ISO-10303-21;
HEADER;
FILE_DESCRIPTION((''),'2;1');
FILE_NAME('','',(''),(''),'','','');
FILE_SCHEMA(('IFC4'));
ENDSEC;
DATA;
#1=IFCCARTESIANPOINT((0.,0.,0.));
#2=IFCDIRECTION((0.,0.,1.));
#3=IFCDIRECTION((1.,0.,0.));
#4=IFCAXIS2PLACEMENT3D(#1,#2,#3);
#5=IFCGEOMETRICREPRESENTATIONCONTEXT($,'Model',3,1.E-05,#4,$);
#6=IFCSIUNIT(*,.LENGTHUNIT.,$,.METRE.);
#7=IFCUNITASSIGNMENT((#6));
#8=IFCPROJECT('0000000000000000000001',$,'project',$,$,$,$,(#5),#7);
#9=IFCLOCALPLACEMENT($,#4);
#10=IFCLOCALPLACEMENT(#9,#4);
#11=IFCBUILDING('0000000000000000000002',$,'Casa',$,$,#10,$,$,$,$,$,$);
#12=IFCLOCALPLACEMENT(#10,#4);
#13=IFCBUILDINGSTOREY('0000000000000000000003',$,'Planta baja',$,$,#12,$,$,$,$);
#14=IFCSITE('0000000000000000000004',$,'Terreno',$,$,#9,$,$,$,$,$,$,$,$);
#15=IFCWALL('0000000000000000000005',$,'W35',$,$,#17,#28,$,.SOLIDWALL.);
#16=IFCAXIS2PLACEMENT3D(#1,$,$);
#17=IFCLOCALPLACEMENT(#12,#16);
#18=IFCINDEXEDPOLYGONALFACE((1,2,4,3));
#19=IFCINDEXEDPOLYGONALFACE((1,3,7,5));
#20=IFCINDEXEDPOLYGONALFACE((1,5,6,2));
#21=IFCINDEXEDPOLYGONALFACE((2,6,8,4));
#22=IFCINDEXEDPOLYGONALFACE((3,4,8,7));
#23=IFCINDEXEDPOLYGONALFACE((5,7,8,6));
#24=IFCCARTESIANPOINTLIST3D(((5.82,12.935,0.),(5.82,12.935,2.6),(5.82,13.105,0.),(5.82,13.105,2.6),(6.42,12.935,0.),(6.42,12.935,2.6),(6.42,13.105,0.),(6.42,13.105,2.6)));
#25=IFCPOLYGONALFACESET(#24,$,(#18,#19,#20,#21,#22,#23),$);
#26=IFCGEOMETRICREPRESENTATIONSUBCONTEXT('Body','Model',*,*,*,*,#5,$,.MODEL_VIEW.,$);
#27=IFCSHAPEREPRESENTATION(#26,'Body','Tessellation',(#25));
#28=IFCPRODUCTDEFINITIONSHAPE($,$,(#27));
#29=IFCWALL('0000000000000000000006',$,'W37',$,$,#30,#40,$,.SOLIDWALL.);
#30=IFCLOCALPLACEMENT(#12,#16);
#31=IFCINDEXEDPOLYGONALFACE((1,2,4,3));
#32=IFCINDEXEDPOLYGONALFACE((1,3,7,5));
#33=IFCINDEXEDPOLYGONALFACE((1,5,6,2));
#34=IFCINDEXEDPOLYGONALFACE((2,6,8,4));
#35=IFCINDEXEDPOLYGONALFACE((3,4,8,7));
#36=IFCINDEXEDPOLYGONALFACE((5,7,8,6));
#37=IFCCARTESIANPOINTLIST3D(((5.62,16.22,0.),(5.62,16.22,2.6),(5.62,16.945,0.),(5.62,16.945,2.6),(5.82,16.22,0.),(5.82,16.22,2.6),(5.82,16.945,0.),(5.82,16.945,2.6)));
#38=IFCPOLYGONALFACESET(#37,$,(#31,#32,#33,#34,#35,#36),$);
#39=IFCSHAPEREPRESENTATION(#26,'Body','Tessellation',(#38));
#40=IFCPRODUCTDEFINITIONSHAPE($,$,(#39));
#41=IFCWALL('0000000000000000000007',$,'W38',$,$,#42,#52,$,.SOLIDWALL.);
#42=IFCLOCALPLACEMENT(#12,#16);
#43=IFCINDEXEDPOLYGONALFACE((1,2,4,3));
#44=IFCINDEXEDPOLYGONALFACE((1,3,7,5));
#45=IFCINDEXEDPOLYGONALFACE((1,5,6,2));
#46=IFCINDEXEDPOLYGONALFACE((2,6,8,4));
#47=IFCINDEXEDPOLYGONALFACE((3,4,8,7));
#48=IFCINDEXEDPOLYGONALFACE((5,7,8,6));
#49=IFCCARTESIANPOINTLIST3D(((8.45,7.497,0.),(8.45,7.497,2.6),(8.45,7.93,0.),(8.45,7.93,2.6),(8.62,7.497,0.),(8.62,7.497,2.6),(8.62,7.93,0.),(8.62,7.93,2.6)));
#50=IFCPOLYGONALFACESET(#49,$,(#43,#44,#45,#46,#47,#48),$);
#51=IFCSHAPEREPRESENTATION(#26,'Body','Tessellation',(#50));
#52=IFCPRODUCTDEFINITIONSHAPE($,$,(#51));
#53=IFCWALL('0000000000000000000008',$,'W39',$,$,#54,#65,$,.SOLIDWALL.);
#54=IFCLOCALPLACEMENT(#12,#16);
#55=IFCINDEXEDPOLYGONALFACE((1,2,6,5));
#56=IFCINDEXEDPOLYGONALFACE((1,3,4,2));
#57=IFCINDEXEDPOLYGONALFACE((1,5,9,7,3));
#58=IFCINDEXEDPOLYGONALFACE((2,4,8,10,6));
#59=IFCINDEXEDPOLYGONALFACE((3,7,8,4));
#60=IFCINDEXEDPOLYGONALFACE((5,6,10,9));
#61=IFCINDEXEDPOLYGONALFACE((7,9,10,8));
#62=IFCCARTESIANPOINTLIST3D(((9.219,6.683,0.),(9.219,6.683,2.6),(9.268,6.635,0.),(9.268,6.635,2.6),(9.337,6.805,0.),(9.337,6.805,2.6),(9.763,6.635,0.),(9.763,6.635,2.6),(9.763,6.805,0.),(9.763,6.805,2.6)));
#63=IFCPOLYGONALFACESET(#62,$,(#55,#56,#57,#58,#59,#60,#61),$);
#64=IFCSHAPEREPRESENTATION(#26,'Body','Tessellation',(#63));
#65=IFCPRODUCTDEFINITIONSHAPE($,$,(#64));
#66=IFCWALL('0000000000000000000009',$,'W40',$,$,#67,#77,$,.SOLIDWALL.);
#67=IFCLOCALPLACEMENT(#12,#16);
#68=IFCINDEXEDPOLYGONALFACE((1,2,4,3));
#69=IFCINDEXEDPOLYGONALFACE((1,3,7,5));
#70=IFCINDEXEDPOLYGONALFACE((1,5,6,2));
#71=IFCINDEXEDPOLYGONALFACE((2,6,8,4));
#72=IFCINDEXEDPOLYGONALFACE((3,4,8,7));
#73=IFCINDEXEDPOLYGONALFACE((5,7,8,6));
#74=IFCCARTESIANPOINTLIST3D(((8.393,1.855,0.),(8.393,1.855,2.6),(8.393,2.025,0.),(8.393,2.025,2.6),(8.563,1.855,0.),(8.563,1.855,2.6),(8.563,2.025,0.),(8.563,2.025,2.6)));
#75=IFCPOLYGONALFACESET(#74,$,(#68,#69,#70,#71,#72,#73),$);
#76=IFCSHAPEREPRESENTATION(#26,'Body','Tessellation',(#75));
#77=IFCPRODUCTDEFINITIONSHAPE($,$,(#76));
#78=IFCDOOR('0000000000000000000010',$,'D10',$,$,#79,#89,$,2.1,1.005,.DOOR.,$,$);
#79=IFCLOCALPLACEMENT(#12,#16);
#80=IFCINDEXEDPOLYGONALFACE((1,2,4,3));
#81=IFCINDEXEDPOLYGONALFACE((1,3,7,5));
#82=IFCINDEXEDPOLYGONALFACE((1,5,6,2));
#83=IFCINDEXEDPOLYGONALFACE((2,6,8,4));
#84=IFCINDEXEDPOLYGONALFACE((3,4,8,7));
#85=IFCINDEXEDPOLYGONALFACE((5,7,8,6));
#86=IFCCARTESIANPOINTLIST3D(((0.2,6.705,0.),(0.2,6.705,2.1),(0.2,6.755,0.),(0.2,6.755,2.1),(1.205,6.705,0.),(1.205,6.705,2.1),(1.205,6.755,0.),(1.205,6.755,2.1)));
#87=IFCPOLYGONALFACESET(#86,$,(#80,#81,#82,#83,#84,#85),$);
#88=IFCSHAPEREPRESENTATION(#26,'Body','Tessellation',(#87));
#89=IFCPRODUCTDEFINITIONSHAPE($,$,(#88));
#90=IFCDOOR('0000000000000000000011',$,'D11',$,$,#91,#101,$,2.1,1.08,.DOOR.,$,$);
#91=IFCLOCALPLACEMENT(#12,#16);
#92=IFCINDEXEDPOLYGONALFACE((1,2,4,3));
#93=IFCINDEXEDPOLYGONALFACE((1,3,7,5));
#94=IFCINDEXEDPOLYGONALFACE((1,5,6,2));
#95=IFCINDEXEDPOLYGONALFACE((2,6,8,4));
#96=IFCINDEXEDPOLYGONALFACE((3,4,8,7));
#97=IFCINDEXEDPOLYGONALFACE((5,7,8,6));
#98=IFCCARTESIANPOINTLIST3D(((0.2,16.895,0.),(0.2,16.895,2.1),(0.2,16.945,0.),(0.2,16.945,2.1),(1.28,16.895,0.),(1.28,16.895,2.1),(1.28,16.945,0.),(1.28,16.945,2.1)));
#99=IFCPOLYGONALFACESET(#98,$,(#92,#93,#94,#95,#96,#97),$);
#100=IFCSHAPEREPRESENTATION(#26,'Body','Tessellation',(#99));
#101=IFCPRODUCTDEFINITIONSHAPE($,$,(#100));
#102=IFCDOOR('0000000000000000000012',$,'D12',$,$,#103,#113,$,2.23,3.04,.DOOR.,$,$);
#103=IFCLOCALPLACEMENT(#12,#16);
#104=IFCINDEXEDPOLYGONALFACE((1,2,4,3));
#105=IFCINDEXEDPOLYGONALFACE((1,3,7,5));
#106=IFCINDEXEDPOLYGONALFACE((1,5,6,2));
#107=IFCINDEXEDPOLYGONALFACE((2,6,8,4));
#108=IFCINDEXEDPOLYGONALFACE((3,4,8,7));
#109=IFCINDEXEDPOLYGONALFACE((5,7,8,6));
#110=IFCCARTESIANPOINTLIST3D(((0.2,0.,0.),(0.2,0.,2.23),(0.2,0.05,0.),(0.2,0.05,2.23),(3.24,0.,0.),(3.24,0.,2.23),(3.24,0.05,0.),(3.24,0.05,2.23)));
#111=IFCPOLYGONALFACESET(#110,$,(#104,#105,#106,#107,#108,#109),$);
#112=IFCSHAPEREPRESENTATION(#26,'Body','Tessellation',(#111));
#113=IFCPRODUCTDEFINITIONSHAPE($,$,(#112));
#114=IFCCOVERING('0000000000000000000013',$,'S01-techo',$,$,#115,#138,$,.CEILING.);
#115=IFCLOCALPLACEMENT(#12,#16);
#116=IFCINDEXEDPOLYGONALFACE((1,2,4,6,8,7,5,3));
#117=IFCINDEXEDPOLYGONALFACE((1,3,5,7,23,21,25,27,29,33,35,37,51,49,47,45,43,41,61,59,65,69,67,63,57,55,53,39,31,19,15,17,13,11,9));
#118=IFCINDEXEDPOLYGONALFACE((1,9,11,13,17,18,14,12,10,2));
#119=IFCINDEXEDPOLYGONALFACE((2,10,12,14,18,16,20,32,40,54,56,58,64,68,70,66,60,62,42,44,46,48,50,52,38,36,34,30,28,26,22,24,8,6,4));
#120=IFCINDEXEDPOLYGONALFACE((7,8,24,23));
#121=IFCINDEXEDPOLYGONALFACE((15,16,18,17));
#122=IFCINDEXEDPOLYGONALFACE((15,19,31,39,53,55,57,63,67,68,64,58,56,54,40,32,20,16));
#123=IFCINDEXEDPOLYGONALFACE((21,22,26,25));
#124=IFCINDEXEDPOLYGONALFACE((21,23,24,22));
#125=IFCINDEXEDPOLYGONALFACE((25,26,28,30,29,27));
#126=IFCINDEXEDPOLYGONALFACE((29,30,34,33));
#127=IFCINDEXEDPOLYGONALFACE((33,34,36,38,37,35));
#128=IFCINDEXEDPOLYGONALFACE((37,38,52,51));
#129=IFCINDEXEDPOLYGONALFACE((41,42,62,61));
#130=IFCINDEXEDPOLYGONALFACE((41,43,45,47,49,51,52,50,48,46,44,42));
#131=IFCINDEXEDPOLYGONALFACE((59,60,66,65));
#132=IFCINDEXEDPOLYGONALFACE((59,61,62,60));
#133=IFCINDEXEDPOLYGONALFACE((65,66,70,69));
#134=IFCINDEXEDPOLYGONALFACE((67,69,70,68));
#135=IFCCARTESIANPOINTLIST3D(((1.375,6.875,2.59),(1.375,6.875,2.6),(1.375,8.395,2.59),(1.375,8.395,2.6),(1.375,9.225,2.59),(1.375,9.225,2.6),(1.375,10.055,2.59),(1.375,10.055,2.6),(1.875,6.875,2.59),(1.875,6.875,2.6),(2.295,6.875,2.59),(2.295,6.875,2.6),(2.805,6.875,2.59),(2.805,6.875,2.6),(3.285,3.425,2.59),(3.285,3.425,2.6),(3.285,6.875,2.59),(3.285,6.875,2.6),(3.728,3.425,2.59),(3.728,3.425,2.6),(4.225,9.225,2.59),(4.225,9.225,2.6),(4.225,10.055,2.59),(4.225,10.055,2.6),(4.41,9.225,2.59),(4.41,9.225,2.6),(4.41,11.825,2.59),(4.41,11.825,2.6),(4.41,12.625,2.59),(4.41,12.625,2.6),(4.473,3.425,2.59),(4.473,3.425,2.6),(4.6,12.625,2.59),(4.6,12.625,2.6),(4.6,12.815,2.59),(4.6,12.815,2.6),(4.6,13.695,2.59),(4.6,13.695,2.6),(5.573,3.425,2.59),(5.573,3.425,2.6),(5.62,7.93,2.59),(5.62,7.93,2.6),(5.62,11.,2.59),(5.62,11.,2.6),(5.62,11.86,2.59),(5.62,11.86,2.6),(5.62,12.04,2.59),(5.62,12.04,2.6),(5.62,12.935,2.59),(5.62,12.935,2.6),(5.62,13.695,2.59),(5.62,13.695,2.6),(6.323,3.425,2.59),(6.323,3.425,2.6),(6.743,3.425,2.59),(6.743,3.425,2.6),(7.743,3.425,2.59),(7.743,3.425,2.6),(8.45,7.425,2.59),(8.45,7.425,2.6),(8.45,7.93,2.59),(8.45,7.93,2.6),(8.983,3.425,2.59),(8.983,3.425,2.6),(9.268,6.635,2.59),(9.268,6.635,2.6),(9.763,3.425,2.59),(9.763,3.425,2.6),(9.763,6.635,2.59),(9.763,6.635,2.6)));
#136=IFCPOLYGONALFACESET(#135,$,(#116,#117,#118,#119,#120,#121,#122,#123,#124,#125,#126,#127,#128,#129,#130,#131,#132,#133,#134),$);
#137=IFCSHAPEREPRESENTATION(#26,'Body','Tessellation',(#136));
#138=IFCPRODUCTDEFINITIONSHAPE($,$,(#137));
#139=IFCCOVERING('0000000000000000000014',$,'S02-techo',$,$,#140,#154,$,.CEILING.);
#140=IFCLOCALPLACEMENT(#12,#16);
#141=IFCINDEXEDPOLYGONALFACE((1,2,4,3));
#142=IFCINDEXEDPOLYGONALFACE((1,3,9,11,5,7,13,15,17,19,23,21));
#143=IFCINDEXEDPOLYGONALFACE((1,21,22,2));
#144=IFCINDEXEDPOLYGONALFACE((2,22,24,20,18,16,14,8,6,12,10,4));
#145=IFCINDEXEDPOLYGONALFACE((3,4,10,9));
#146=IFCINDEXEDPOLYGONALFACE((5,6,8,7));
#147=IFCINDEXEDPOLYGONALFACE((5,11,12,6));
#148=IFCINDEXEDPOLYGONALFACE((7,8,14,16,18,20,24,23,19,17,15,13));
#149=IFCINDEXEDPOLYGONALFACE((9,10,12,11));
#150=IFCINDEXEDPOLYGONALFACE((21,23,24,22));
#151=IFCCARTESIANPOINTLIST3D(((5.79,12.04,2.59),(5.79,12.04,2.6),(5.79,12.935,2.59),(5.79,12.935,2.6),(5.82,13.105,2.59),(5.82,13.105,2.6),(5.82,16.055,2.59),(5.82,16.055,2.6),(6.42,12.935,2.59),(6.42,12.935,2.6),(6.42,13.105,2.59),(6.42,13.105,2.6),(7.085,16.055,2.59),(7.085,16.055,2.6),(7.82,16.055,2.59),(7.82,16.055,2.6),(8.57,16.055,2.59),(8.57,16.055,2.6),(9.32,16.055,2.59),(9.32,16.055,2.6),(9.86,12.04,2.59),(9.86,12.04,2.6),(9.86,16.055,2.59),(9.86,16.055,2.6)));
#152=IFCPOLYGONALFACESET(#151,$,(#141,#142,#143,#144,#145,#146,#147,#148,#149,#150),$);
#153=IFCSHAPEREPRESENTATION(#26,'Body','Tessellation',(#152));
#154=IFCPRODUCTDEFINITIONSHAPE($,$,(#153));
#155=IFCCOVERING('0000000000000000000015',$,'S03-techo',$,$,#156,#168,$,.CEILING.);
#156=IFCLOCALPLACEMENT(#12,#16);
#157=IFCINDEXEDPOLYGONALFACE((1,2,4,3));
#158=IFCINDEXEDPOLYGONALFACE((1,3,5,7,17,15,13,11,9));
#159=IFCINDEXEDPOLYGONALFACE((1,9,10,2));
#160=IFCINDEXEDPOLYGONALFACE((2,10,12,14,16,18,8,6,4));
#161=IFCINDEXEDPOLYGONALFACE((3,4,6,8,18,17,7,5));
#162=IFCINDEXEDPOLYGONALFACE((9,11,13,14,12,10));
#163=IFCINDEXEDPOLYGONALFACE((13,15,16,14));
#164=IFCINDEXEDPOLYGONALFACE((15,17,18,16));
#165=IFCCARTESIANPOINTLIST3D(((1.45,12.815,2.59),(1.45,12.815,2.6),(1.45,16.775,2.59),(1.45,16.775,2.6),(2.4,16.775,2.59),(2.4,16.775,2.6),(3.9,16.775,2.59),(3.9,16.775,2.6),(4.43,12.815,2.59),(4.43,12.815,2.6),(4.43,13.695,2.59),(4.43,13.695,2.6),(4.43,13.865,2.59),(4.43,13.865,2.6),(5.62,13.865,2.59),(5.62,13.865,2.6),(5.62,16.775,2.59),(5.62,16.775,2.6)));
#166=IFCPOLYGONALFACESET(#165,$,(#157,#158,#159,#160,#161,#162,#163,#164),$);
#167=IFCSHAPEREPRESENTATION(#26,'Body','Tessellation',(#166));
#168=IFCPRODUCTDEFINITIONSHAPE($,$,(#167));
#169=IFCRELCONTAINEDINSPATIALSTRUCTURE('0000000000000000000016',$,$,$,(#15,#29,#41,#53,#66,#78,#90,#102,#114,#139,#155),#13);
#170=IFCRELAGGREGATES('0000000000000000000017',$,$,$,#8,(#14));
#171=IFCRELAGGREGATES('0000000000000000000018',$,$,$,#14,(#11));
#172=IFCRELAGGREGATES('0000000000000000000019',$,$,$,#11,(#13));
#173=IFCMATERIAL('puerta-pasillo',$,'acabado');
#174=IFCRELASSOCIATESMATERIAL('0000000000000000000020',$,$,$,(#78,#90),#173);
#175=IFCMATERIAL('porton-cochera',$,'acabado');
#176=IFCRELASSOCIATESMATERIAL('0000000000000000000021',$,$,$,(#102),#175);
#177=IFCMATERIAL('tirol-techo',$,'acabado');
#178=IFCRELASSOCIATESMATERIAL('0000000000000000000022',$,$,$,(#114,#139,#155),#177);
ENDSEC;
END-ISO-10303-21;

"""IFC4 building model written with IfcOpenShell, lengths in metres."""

from ifc_helpers import new_model, si_unit, frame, origin_with_axes, place, context, subcontext, project, spatial, line, indexed_curve, outline, extrude, material, element, save


model = new_model("IFC4")

# Units and contexts
model_context = context("Model", 3, precision=1e-05, world=origin_with_axes())
body_context = subcontext(model_context, "Body", "Model", "MODEL_VIEW")
ifc_project = project(units=[si_unit("LENGTHUNIT", "METRE")], contexts=[model_context])

# Site, building, storey
site_placement = place(None, origin_with_axes())
site = spatial("IfcSite", under=ifc_project, at=site_placement, Name="Terreno")
building_placement = place(site_placement, origin_with_axes())
building = spatial("IfcBuilding", under=site, at=building_placement, Name="Casa")
storey_placement = place(building_placement, origin_with_axes())
storey = spatial("IfcBuildingStorey", under=building, at=storey_placement, Name="Planta baja")

# Walls
wall_1_placement = place(storey_placement, origin_with_axes())
element("IfcWall", 1, at=wall_1_placement, inside=storey, Name="W35", PredefinedType="SOLIDWALL", context=body_context, shape_type="SweptSolid", body=[
    extrude(outline(indexed_curve([(6.42, 13.105), (6.42, 12.935), (5.82, 12.935), (5.82, 13.105)], segments=[line(1, 2, 3, 4, 1)])), origin_with_axes(), (0.0, 0.0, 1.0), 2.6),
])
wall_2_placement = place(storey_placement, origin_with_axes())
element("IfcWall", 2, at=wall_2_placement, inside=storey, Name="W37", PredefinedType="SOLIDWALL", context=body_context, shape_type="SweptSolid", body=[
    extrude(outline(indexed_curve([(5.62, 16.945), (5.82, 16.945), (5.82, 16.22), (5.62, 16.22)], segments=[line(1, 2, 3, 4, 1)])), origin_with_axes(), (0.0, 0.0, 1.0), 2.6),
])
wall_3_placement = place(storey_placement, origin_with_axes())
element("IfcWall", 3, at=wall_3_placement, inside=storey, Name="W38", PredefinedType="SOLIDWALL", context=body_context, shape_type="SweptSolid", body=[
    extrude(outline(indexed_curve([(8.62, 7.93), (8.62, 7.497), (8.45, 7.497), (8.45, 7.93)], segments=[line(1, 2, 3, 4, 1)])), origin_with_axes(), (0.0, 0.0, 1.0), 2.6),
])
wall_4_placement = place(storey_placement, origin_with_axes())
element("IfcWall", 4, at=wall_4_placement, inside=storey, Name="W39", PredefinedType="SOLIDWALL", context=body_context, shape_type="SweptSolid", body=[
    extrude(outline(indexed_curve([(9.337, 6.805), (9.763, 6.805), (9.763, 6.635), (9.268, 6.635), (9.219, 6.683)], segments=[line(1, 2, 3, 4, 5, 1)])), origin_with_axes(), (0.0, 0.0, 1.0), 2.6),
])
wall_5_placement = place(storey_placement, origin_with_axes())
element("IfcWall", 5, at=wall_5_placement, inside=storey, Name="W40", PredefinedType="SOLIDWALL", context=body_context, shape_type="SweptSolid", body=[
    extrude(outline(indexed_curve([(8.563, 1.855), (8.393, 1.855), (8.393, 2.025), (8.563, 2.025)], segments=[line(1, 2, 3, 4, 1)])), origin_with_axes(), (0.0, 0.0, 1.0), 2.6),
])

# Doors
ifc_material_1 = material(Name="puerta-pasillo", Category="acabado")
door_1_placement = place(storey_placement, origin_with_axes())
element("IfcDoor", 6, at=door_1_placement, inside=storey, material=ifc_material_1, Name="D10", OverallHeight=2.1, OverallWidth=1.005, PredefinedType="DOOR", context=body_context, shape_type="SweptSolid", body=[
    extrude(outline(indexed_curve([(0.2, 6.705), (1.205, 6.705), (1.205, 6.755), (0.2, 6.755)], segments=[line(1, 2, 3, 4, 1)])), origin_with_axes(), (0.0, 0.0, 1.0), 2.1),
])
door_2_placement = place(storey_placement, origin_with_axes())
element("IfcDoor", 7, at=door_2_placement, inside=storey, material=ifc_material_1, Name="D11", OverallHeight=2.1, OverallWidth=1.08, PredefinedType="DOOR", context=body_context, shape_type="SweptSolid", body=[
    extrude(outline(indexed_curve([(0.2, 16.895), (1.28, 16.895), (1.28, 16.945), (0.2, 16.945)], segments=[line(1, 2, 3, 4, 1)])), origin_with_axes(), (0.0, 0.0, 1.0), 2.1),
])
ifc_material_2 = material(Name="porton-cochera", Category="acabado")
door_3_placement = place(storey_placement, origin_with_axes())
element("IfcDoor", 8, at=door_3_placement, inside=storey, material=ifc_material_2, Name="D12", OverallHeight=2.23, OverallWidth=3.04, PredefinedType="DOOR", context=body_context, shape_type="SweptSolid", body=[
    extrude(outline(indexed_curve([(0.2, 0.0), (3.24, 0.0), (3.24, 0.05), (0.2, 0.05)], segments=[line(1, 2, 3, 4, 1)])), origin_with_axes(), (0.0, 0.0, 1.0), 2.23),
])

# Coverings
ifc_material_3 = material(Name="tirol-techo", Category="acabado")
covering_1_placement = place(storey_placement, origin_with_axes())
element("IfcCovering", 9, at=covering_1_placement, inside=storey, material=ifc_material_3, Name="S01-techo", PredefinedType="CEILING", context=body_context, shape_type="SweptSolid", body=[
    extrude(outline(indexed_curve([(4.6, 12.625), (4.6, 12.815), (4.6, 13.695), (5.62, 13.695), (5.62, 12.935), (5.62, 12.04), (5.62, 11.86), (5.62, 11.0), (5.62, 7.93), (8.45, 7.93), (8.45, 7.425), (9.268, 6.635), (9.763, 6.635), (9.763, 3.425), (8.983, 3.425), (7.743, 3.425), (6.743, 3.425), (6.323, 3.425), (5.573, 3.425), (4.473, 3.425), (3.728, 3.425), (3.285, 3.425), (3.285, 6.875), (2.805, 6.875), (2.295, 6.875), (1.875, 6.875), (1.375, 6.875), (1.375, 8.395), (1.375, 9.225), (1.375, 10.055), (4.225, 10.055), (4.225, 9.225), (4.41, 9.225), (4.41, 11.825), (4.41, 12.625)], segments=[line(1, 2, 3, 4, 5, 6, 7, 8, 9, 10, 11, 12, 13, 14, 15, 16, 17, 18, 19, 20, 21, 22, 23, 24, 25, 26, 27, 28, 29, 30, 31, 32, 33, 34, 35, 1)])), frame((0.0, 0.0, 2.59), z_axis=(0.0, 0.0, 1.0), x_axis=(1.0, 0.0, 0.0)), (0.0, 0.0, 1.0), 0.01),
])
covering_2_placement = place(storey_placement, origin_with_axes())
element("IfcCovering", 10, at=covering_2_placement, inside=storey, material=ifc_material_3, Name="S02-techo", PredefinedType="CEILING", context=body_context, shape_type="SweptSolid", body=[
    extrude(outline(indexed_curve([(5.79, 12.935), (6.42, 12.935), (6.42, 13.105), (5.82, 13.105), (5.82, 16.055), (7.085, 16.055), (7.82, 16.055), (8.57, 16.055), (9.32, 16.055), (9.86, 16.055), (9.86, 12.04), (5.79, 12.04)], segments=[line(1, 2, 3, 4, 5, 6, 7, 8, 9, 10, 11, 12, 1)])), frame((0.0, 0.0, 2.59), z_axis=(0.0, 0.0, 1.0), x_axis=(1.0, 0.0, 0.0)), (0.0, 0.0, 1.0), 0.01),
])
covering_3_placement = place(storey_placement, origin_with_axes())
element("IfcCovering", 11, at=covering_3_placement, inside=storey, material=ifc_material_3, Name="S03-techo", PredefinedType="CEILING", context=body_context, shape_type="SweptSolid", body=[
    extrude(outline(indexed_curve([(1.45, 16.775), (2.4, 16.775), (3.9, 16.775), (5.62, 16.775), (5.62, 13.865), (4.43, 13.865), (4.43, 13.695), (4.43, 12.815), (1.45, 12.815)], segments=[line(1, 2, 3, 4, 5, 6, 7, 8, 9, 1)])), frame((0.0, 0.0, 2.59), z_axis=(0.0, 0.0, 1.0), x_axis=(1.0, 0.0, 0.0)), (0.0, 0.0, 1.0), 0.01),
])

save(model, "model.ifc")
